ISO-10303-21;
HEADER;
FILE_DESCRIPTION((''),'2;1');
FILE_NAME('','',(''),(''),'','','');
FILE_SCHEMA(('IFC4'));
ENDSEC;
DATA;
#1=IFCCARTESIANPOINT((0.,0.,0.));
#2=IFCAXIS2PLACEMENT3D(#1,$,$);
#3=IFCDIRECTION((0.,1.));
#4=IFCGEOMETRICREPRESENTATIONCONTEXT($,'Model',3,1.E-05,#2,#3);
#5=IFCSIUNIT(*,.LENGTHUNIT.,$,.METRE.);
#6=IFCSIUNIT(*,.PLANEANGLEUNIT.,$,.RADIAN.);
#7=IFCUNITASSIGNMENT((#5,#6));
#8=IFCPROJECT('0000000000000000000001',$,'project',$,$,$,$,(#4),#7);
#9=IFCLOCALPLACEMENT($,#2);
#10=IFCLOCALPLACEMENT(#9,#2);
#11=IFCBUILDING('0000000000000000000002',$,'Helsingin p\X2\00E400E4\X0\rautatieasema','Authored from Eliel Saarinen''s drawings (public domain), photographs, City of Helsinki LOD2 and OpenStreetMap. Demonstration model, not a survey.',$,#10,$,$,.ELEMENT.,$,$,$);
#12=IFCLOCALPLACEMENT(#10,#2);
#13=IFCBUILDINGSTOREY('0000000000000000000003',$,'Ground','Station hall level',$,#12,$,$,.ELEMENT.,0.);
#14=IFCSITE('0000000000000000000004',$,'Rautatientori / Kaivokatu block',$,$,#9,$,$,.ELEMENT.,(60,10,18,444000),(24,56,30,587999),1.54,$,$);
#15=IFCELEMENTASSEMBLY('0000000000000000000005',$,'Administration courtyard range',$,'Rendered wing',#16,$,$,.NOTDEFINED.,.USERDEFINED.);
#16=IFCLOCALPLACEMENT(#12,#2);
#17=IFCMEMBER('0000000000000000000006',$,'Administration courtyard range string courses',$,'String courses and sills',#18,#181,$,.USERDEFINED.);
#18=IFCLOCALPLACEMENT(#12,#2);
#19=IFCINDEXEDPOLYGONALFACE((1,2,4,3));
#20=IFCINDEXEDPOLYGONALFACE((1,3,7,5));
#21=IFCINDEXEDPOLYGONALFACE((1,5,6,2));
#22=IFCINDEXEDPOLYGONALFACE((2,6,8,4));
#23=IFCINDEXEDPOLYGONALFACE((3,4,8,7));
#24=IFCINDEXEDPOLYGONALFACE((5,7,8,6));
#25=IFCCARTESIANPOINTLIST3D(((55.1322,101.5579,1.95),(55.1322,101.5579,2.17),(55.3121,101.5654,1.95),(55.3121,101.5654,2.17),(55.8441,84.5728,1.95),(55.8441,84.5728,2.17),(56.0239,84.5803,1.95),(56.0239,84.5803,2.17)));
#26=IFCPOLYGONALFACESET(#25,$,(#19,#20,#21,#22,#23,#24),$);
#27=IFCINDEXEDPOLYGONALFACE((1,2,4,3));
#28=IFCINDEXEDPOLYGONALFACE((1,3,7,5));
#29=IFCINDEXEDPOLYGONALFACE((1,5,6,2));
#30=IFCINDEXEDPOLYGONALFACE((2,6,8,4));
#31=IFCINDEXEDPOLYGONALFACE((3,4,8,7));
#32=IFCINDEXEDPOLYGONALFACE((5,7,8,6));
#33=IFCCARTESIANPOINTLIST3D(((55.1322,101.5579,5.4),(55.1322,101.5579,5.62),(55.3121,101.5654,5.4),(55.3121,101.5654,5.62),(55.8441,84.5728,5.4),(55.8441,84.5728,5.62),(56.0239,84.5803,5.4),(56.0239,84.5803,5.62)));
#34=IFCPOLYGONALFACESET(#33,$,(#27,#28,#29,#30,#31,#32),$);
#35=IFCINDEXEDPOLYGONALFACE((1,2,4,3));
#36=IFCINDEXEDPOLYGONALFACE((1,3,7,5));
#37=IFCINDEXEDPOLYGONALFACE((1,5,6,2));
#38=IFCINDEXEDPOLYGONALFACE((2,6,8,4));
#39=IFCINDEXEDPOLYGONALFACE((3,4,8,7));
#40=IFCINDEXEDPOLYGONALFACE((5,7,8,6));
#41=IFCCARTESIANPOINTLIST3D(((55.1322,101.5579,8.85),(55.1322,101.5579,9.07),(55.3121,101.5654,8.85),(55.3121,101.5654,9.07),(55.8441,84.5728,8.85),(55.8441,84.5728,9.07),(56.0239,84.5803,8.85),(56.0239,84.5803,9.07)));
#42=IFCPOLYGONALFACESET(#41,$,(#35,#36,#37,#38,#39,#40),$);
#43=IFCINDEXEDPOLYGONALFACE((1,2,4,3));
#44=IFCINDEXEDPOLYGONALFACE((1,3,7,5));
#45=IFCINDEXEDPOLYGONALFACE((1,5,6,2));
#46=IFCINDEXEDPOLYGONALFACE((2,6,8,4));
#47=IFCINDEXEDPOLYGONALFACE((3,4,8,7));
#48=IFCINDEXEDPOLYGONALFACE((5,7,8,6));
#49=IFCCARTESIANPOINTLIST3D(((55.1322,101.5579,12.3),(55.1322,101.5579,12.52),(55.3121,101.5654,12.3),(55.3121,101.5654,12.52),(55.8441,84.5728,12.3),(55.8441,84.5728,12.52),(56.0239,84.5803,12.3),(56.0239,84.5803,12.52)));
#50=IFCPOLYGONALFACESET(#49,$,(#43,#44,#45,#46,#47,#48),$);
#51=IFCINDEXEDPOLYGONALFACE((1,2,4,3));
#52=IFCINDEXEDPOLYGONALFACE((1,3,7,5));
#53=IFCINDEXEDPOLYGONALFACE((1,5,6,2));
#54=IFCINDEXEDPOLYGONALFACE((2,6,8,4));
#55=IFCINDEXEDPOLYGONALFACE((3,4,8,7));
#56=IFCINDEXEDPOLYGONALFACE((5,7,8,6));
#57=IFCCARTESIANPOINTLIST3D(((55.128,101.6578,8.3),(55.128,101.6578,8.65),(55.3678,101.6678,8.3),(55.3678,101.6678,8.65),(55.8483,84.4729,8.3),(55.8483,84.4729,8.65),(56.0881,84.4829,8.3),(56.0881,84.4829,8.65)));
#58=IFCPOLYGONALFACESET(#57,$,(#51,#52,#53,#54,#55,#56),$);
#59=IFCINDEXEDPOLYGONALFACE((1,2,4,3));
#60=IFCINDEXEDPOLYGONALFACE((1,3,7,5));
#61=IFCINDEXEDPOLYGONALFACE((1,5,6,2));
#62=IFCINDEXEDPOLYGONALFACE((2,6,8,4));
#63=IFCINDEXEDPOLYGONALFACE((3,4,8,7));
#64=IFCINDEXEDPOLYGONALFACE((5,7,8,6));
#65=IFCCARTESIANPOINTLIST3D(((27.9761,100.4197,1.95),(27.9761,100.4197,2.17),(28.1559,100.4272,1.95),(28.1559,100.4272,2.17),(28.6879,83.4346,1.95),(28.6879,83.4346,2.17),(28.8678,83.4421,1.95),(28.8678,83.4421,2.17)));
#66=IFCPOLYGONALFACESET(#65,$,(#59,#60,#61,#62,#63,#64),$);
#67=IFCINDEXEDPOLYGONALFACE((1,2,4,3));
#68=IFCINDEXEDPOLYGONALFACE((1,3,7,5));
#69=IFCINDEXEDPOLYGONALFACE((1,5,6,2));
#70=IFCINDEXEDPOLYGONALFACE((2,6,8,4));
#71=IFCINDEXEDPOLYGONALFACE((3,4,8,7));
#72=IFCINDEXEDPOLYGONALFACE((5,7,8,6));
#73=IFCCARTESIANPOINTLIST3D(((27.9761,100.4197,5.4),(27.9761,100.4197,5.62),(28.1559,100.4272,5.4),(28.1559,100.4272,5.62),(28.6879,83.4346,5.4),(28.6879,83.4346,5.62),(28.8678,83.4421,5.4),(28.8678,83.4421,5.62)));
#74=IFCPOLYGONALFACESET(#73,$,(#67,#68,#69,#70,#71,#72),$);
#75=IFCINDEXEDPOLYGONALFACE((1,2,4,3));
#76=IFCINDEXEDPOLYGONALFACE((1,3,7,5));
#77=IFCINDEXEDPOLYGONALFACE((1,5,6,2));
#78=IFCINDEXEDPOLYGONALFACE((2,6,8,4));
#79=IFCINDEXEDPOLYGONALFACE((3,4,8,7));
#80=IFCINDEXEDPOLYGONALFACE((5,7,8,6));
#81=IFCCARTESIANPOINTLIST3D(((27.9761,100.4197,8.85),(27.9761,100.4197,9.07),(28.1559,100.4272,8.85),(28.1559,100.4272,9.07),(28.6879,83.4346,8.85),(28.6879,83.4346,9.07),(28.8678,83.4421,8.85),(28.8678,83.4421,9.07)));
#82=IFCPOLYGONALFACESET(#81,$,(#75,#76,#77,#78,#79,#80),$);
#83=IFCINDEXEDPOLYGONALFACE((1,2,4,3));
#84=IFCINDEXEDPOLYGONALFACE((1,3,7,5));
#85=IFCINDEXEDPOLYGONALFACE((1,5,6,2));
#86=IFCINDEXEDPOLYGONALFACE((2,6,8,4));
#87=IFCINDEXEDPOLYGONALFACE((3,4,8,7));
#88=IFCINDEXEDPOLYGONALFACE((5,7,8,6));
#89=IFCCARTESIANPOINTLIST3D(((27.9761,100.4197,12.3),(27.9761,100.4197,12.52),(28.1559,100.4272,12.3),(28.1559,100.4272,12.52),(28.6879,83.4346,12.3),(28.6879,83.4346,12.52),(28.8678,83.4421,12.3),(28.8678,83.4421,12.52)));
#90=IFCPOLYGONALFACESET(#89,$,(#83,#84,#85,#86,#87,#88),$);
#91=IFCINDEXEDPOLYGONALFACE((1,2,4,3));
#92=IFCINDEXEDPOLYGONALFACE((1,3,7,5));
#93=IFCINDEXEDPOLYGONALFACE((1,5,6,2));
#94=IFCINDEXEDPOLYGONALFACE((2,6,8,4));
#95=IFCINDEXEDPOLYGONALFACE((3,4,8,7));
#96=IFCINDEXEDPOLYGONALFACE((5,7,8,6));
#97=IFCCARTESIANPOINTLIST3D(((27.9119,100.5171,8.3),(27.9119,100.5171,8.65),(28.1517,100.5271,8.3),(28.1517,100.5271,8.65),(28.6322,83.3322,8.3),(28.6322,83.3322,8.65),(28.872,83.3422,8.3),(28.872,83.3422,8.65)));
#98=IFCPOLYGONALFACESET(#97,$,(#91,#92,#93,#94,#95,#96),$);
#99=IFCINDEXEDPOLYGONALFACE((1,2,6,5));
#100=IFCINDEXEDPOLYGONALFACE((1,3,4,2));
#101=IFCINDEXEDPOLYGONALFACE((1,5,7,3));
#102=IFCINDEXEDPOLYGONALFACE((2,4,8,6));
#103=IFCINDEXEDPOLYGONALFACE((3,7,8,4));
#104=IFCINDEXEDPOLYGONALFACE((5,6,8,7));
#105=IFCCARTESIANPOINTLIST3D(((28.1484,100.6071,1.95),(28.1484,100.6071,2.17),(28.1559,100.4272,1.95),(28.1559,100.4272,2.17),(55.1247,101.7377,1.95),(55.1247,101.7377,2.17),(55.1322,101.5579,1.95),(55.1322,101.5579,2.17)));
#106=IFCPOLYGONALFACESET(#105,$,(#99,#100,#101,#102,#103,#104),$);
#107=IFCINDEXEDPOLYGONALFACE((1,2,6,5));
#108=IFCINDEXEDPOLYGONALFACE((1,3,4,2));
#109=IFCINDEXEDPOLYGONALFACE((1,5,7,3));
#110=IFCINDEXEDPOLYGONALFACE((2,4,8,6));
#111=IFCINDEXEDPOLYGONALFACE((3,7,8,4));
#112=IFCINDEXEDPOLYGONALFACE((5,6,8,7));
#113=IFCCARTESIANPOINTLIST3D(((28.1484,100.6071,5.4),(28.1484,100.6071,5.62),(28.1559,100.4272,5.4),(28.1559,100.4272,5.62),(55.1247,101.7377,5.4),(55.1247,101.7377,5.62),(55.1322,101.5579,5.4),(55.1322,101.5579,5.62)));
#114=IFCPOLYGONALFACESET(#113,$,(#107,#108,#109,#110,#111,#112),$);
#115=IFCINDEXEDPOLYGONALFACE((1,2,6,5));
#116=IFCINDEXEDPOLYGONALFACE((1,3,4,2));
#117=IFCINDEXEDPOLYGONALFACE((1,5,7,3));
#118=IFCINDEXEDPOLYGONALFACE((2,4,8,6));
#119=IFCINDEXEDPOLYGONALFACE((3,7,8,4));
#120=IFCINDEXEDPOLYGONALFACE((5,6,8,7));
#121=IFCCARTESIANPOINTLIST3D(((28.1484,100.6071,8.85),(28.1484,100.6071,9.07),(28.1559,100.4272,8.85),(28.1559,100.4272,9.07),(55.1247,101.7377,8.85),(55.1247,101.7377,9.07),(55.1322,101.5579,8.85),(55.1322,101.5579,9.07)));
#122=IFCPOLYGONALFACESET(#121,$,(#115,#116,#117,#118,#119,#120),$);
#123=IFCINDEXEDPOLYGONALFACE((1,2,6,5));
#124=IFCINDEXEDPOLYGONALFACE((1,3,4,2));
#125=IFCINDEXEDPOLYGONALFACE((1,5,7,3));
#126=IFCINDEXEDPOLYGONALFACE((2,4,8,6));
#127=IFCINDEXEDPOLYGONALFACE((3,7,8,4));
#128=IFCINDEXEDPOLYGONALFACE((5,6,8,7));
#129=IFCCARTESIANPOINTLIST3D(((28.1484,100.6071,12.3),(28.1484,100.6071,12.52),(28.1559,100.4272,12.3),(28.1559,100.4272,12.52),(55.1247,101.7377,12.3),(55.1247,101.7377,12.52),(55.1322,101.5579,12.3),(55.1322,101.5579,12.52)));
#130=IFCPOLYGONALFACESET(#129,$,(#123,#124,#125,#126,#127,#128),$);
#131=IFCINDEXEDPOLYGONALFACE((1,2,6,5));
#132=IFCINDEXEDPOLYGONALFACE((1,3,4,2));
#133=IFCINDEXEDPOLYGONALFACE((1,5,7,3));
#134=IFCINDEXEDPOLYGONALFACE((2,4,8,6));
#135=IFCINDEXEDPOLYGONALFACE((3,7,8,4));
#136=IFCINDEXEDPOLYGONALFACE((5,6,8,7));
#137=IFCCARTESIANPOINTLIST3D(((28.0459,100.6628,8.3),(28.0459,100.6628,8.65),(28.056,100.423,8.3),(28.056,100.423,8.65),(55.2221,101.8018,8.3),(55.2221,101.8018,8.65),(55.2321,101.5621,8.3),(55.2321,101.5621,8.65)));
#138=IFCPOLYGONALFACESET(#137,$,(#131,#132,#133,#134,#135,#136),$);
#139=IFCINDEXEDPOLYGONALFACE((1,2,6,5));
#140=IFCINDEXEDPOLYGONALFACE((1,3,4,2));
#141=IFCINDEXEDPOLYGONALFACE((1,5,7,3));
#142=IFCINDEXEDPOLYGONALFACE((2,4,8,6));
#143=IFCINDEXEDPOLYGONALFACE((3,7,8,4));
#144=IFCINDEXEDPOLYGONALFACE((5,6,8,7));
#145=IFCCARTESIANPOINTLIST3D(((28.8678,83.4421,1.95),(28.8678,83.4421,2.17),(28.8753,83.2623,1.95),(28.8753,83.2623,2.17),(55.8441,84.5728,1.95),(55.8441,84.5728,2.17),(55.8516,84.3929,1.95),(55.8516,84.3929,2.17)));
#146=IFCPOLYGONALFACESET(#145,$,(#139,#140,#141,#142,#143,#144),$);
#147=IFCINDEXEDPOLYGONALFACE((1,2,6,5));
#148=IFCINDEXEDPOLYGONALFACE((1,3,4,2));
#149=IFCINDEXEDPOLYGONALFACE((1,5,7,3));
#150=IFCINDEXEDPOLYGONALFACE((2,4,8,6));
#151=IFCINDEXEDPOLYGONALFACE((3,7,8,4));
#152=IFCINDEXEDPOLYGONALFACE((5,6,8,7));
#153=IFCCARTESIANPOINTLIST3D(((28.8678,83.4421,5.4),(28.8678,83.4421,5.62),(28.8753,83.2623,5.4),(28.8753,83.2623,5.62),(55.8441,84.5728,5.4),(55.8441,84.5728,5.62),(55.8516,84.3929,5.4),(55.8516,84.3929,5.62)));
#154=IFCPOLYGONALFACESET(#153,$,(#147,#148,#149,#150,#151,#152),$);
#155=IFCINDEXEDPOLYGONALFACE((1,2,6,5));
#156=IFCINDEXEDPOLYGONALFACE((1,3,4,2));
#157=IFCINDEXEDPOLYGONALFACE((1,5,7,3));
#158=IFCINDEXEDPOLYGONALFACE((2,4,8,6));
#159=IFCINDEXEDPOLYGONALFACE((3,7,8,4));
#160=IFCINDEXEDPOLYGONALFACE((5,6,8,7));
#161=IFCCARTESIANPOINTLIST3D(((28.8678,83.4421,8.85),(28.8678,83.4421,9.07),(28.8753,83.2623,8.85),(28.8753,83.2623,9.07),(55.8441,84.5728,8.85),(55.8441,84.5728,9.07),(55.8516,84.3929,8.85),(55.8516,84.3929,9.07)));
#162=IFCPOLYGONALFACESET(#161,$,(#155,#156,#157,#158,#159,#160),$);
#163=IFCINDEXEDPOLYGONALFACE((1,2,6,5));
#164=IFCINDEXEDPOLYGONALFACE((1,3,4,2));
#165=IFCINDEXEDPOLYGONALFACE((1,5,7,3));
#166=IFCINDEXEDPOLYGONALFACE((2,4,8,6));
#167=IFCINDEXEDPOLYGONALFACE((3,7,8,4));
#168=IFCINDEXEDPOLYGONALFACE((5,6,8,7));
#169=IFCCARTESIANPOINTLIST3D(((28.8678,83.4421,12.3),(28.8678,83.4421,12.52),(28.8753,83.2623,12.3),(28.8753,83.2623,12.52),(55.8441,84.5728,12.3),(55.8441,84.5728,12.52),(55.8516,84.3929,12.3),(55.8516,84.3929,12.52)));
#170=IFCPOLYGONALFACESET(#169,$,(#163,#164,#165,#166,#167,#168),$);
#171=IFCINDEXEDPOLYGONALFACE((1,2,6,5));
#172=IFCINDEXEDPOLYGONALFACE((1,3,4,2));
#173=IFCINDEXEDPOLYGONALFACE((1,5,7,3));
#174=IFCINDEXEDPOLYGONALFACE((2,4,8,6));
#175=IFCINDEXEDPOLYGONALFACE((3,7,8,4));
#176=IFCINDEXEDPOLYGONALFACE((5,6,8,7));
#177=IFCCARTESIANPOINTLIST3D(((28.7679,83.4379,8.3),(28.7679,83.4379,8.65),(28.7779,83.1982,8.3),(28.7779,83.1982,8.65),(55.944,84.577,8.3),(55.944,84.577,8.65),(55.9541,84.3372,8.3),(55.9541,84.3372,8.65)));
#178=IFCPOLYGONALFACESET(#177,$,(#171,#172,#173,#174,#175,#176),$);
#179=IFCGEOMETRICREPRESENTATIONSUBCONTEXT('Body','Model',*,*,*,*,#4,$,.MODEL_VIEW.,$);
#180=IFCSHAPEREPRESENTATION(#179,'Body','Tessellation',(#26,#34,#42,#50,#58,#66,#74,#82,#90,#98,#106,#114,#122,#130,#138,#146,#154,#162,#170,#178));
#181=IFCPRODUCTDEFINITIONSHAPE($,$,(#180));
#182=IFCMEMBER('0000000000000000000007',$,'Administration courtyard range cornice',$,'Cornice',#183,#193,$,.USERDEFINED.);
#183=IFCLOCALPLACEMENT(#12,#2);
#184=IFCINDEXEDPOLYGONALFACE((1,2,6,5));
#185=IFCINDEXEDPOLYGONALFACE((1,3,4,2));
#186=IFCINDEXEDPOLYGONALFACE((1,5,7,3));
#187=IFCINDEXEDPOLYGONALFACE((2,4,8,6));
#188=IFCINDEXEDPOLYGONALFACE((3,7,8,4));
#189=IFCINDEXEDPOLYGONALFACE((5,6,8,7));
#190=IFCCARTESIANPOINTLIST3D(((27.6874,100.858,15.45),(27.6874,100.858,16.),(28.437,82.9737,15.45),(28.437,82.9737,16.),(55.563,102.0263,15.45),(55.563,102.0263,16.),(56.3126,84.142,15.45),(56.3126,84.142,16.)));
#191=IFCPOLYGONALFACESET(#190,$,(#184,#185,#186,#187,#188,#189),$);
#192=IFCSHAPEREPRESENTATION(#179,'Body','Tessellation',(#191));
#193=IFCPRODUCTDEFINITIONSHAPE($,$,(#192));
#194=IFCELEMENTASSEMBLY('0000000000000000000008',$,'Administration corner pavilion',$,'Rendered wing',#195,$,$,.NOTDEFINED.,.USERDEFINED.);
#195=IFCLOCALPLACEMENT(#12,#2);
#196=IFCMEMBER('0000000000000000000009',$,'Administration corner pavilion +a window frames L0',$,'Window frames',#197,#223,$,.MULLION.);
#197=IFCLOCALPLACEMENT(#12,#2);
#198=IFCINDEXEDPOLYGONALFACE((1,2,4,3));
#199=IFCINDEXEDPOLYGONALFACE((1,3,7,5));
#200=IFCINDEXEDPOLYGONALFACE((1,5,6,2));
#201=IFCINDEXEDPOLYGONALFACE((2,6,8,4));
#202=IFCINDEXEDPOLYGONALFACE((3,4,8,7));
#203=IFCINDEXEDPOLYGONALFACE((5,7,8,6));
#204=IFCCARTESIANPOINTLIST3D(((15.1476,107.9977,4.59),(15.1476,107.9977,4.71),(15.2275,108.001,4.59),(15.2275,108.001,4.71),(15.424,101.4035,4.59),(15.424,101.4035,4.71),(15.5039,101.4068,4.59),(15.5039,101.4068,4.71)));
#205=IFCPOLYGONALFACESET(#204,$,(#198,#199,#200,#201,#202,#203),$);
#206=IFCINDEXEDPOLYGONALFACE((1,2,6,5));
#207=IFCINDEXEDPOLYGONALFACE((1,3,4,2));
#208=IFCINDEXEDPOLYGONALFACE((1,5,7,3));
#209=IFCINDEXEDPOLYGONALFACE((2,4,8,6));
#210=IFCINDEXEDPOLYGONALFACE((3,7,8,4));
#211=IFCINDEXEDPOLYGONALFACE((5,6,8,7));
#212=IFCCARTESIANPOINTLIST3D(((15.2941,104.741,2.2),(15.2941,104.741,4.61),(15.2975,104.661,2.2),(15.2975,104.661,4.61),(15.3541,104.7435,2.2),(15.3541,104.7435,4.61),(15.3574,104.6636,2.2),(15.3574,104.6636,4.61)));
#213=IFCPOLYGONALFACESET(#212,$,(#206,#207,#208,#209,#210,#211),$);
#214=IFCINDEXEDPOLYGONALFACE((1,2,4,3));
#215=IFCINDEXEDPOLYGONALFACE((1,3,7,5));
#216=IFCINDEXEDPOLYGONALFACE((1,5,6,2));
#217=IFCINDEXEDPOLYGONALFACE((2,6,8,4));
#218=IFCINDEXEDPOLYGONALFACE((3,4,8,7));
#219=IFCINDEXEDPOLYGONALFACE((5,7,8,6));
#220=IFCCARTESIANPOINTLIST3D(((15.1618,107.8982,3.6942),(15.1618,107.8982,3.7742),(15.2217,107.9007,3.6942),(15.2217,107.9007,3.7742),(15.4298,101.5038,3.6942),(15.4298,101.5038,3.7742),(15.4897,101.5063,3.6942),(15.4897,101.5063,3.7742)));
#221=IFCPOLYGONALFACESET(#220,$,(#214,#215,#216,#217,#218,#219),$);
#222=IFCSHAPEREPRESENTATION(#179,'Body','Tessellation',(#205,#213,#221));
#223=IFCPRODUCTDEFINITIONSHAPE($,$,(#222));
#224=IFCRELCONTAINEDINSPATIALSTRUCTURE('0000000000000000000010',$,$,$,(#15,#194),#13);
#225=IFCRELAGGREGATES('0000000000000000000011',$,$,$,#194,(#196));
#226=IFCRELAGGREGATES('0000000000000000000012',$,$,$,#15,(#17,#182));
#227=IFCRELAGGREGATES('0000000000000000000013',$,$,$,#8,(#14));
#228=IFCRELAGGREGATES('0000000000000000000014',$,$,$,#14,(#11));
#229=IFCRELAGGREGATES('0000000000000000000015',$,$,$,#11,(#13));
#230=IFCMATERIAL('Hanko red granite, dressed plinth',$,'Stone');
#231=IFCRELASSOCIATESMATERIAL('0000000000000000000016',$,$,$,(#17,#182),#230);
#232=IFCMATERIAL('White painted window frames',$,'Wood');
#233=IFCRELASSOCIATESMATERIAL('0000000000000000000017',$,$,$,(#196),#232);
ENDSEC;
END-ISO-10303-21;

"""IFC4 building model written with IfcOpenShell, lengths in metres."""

from ifc_helpers import new_model, si_unit, direction, frame, frame_2d, origin, place, context, subcontext, project, spatial, rectangle, extrude, material, element, aggregate, save


model = new_model("IFC4")

# Units and contexts
model_context = context("Model", 3, precision=1e-05, world=origin(), true_north=direction((0.0, 1.0)))
body_context = subcontext(model_context, "Body", "Model", "MODEL_VIEW")
ifc_project = project(units=[si_unit("LENGTHUNIT", "METRE"), si_unit("PLANEANGLEUNIT", "RADIAN")], contexts=[model_context])

# Site, building, storey
site_placement = place(None, origin())
site = spatial("IfcSite", under=ifc_project, at=site_placement, Name="Rautatientori / Kaivokatu block", CompositionType="ELEMENT", RefLatitude=(60, 10, 18, 444000), RefLongitude=(24, 56, 30, 587999), RefElevation=1.54)
building_placement = place(site_placement, origin())
building = spatial("IfcBuilding", under=site, at=building_placement, Name="Helsingin päärautatieasema", Description="Authored from Eliel Saarinen's drawings (public domain), photographs, City of Helsinki LOD2 and OpenStreetMap. Demonstration model, not a survey.", CompositionType="ELEMENT")
storey_placement = place(building_placement, origin())
storey = spatial("IfcBuildingStorey", under=building, at=storey_placement, Name="Ground", Description="Station hall level", CompositionType="ELEMENT", Elevation=0.0)

# Element assembly, members
assembly_1_placement = place(building_placement, origin())
assembly_1 = element("IfcElementAssembly", 1, at=assembly_1_placement, inside=storey, Name="Administration courtyard range", ObjectType="Rendered wing", AssemblyPlace="NOTDEFINED", PredefinedType="USERDEFINED")
ifc_material_1 = material(Name="Hanko red granite, dressed plinth", Category="Stone")
member_1_placement = place(building_placement, origin())
member_1 = element("IfcMember", 2, at=member_1_placement, material=ifc_material_1, Name="Administration courtyard range string courses", ObjectType="String courses and sills", PredefinedType="USERDEFINED", context=body_context, shape_type="SweptSolid", body=[
    extrude(rectangle(XDim=17.0, YDim=0.18, at=frame_2d((0.0, 0.0), x_axis=(-0.041876, 0.999123))), frame((55.5781, 93.0691, 1.95)), (0.0, 0.0, 1.0), 0.22),
    extrude(rectangle(XDim=17.0, YDim=0.18, at=frame_2d((0.0, 0.0), x_axis=(-0.041876, 0.999123))), frame((55.5781, 93.0691, 5.4)), (0.0, 0.0, 1.0), 0.22),
    extrude(rectangle(XDim=17.0, YDim=0.18, at=frame_2d((0.0, 0.0), x_axis=(-0.041876, 0.999123))), frame((55.5781, 93.0691, 8.85)), (0.0, 0.0, 1.0), 0.22),
    extrude(rectangle(XDim=17.0, YDim=0.18, at=frame_2d((0.0, 0.0), x_axis=(-0.041876, 0.999123))), frame((55.5781, 93.0691, 12.3)), (0.0, 0.0, 1.0), 0.22),
    extrude(rectangle(XDim=17.2, YDim=0.24, at=frame_2d((0.0, 0.0), x_axis=(-0.041876, 0.999123))), frame((55.6081, 93.0703, 8.3)), (0.0, 0.0, 1.0), 0.35),
    extrude(rectangle(XDim=17.0, YDim=0.18, at=frame_2d((0.0, 0.0), x_axis=(0.041876, -0.999123))), frame((28.4219, 91.9309, 1.95)), (0.0, 0.0, 1.0), 0.22),
    extrude(rectangle(XDim=17.0, YDim=0.18, at=frame_2d((0.0, 0.0), x_axis=(0.041876, -0.999123))), frame((28.4219, 91.9309, 5.4)), (0.0, 0.0, 1.0), 0.22),
    extrude(rectangle(XDim=17.0, YDim=0.18, at=frame_2d((0.0, 0.0), x_axis=(0.041876, -0.999123))), frame((28.4219, 91.9309, 8.85)), (0.0, 0.0, 1.0), 0.22),
    extrude(rectangle(XDim=17.0, YDim=0.18, at=frame_2d((0.0, 0.0), x_axis=(0.041876, -0.999123))), frame((28.4219, 91.9309, 12.3)), (0.0, 0.0, 1.0), 0.22),
    extrude(rectangle(XDim=17.2, YDim=0.24, at=frame_2d((0.0, 0.0), x_axis=(0.041876, -0.999123))), frame((28.3919, 91.9297, 8.3)), (0.0, 0.0, 1.0), 0.35),
    extrude(rectangle(XDim=27.0, YDim=0.18, at=frame_2d((0.0, 0.0), x_axis=(-0.999123, -0.041876))), frame((41.6403, 101.0825, 1.95)), (0.0, 0.0, 1.0), 0.22),
    extrude(rectangle(XDim=27.0, YDim=0.18, at=frame_2d((0.0, 0.0), x_axis=(-0.999123, -0.041876))), frame((41.6403, 101.0825, 5.4)), (0.0, 0.0, 1.0), 0.22),
    extrude(rectangle(XDim=27.0, YDim=0.18, at=frame_2d((0.0, 0.0), x_axis=(-0.999123, -0.041876))), frame((41.6403, 101.0825, 8.85)), (0.0, 0.0, 1.0), 0.22),
    extrude(rectangle(XDim=27.0, YDim=0.18, at=frame_2d((0.0, 0.0), x_axis=(-0.999123, -0.041876))), frame((41.6403, 101.0825, 12.3)), (0.0, 0.0, 1.0), 0.22),
    extrude(rectangle(XDim=27.2, YDim=0.24, at=frame_2d((0.0, 0.0), x_axis=(-0.999123, -0.041876))), frame((41.639, 101.1124, 8.3)), (0.0, 0.0, 1.0), 0.35),
    extrude(rectangle(XDim=27.0, YDim=0.18, at=frame_2d((0.0, 0.0), x_axis=(0.999123, 0.041876))), frame((42.3597, 83.9175, 1.95)), (0.0, 0.0, 1.0), 0.22),
    extrude(rectangle(XDim=27.0, YDim=0.18, at=frame_2d((0.0, 0.0), x_axis=(0.999123, 0.041876))), frame((42.3597, 83.9175, 5.4)), (0.0, 0.0, 1.0), 0.22),
    extrude(rectangle(XDim=27.0, YDim=0.18, at=frame_2d((0.0, 0.0), x_axis=(0.999123, 0.041876))), frame((42.3597, 83.9175, 8.85)), (0.0, 0.0, 1.0), 0.22),
    extrude(rectangle(XDim=27.0, YDim=0.18, at=frame_2d((0.0, 0.0), x_axis=(0.999123, 0.041876))), frame((42.3597, 83.9175, 12.3)), (0.0, 0.0, 1.0), 0.22),
    extrude(rectangle(XDim=27.2, YDim=0.24, at=frame_2d((0.0, 0.0), x_axis=(0.999123, 0.041876))), frame((42.361, 83.8876, 8.3)), (0.0, 0.0, 1.0), 0.35),
])
member_2_placement = place(building_placement, origin())
member_2 = element("IfcMember", 3, at=member_2_placement, material=ifc_material_1, Name="Administration courtyard range cornice", ObjectType="Cornice", PredefinedType="USERDEFINED", context=body_context, shape_type="SweptSolid", body=[
    extrude(rectangle(XDim=27.9, YDim=17.9, at=frame_2d((0.0, 0.0), x_axis=(0.999123, 0.041876))), frame((42.0, 92.5, 15.45)), (0.0, 0.0, 1.0), 0.55),
])

# Element assembly, member
assembly_2_placement = place(building_placement, origin())
assembly_2 = element("IfcElementAssembly", 4, at=assembly_2_placement, inside=storey, Name="Administration corner pavilion", ObjectType="Rendered wing", AssemblyPlace="NOTDEFINED", PredefinedType="USERDEFINED")
ifc_material_2 = material(Name="White painted window frames", Category="Wood")
member_3_placement = place(building_placement, origin())
member_3 = element("IfcMember", 5, at=member_3_placement, material=ifc_material_2, Name="Administration corner pavilion +a window frames L0", ObjectType="Window frames", PredefinedType="MULLION", context=body_context, shape_type="SweptSolid", body=[
    extrude(rectangle(XDim=6.6, YDim=0.08, at=frame_2d((0.0, 0.0), x_axis=(-0.041876, 0.999123))), frame((15.3258, 104.7023, 4.59)), (0.0, 0.0, 1.0), 0.12),
    extrude(rectangle(XDim=0.08, YDim=0.06, at=frame_2d((0.0, 0.0), x_axis=(-0.041876, 0.999123))), frame((15.3258, 104.7023, 2.2)), (0.0, 0.0, 1.0), 2.41),
    extrude(rectangle(XDim=6.4, YDim=0.06, at=frame_2d((0.0, 0.0), x_axis=(-0.041876, 0.999123))), frame((15.3258, 104.7023, 3.6942)), (0.0, 0.0, 1.0), 0.08),
])

aggregate(assembly_2, [member_3])

aggregate(assembly_1, [member_1, member_2])

save(model, "model.ifc")
